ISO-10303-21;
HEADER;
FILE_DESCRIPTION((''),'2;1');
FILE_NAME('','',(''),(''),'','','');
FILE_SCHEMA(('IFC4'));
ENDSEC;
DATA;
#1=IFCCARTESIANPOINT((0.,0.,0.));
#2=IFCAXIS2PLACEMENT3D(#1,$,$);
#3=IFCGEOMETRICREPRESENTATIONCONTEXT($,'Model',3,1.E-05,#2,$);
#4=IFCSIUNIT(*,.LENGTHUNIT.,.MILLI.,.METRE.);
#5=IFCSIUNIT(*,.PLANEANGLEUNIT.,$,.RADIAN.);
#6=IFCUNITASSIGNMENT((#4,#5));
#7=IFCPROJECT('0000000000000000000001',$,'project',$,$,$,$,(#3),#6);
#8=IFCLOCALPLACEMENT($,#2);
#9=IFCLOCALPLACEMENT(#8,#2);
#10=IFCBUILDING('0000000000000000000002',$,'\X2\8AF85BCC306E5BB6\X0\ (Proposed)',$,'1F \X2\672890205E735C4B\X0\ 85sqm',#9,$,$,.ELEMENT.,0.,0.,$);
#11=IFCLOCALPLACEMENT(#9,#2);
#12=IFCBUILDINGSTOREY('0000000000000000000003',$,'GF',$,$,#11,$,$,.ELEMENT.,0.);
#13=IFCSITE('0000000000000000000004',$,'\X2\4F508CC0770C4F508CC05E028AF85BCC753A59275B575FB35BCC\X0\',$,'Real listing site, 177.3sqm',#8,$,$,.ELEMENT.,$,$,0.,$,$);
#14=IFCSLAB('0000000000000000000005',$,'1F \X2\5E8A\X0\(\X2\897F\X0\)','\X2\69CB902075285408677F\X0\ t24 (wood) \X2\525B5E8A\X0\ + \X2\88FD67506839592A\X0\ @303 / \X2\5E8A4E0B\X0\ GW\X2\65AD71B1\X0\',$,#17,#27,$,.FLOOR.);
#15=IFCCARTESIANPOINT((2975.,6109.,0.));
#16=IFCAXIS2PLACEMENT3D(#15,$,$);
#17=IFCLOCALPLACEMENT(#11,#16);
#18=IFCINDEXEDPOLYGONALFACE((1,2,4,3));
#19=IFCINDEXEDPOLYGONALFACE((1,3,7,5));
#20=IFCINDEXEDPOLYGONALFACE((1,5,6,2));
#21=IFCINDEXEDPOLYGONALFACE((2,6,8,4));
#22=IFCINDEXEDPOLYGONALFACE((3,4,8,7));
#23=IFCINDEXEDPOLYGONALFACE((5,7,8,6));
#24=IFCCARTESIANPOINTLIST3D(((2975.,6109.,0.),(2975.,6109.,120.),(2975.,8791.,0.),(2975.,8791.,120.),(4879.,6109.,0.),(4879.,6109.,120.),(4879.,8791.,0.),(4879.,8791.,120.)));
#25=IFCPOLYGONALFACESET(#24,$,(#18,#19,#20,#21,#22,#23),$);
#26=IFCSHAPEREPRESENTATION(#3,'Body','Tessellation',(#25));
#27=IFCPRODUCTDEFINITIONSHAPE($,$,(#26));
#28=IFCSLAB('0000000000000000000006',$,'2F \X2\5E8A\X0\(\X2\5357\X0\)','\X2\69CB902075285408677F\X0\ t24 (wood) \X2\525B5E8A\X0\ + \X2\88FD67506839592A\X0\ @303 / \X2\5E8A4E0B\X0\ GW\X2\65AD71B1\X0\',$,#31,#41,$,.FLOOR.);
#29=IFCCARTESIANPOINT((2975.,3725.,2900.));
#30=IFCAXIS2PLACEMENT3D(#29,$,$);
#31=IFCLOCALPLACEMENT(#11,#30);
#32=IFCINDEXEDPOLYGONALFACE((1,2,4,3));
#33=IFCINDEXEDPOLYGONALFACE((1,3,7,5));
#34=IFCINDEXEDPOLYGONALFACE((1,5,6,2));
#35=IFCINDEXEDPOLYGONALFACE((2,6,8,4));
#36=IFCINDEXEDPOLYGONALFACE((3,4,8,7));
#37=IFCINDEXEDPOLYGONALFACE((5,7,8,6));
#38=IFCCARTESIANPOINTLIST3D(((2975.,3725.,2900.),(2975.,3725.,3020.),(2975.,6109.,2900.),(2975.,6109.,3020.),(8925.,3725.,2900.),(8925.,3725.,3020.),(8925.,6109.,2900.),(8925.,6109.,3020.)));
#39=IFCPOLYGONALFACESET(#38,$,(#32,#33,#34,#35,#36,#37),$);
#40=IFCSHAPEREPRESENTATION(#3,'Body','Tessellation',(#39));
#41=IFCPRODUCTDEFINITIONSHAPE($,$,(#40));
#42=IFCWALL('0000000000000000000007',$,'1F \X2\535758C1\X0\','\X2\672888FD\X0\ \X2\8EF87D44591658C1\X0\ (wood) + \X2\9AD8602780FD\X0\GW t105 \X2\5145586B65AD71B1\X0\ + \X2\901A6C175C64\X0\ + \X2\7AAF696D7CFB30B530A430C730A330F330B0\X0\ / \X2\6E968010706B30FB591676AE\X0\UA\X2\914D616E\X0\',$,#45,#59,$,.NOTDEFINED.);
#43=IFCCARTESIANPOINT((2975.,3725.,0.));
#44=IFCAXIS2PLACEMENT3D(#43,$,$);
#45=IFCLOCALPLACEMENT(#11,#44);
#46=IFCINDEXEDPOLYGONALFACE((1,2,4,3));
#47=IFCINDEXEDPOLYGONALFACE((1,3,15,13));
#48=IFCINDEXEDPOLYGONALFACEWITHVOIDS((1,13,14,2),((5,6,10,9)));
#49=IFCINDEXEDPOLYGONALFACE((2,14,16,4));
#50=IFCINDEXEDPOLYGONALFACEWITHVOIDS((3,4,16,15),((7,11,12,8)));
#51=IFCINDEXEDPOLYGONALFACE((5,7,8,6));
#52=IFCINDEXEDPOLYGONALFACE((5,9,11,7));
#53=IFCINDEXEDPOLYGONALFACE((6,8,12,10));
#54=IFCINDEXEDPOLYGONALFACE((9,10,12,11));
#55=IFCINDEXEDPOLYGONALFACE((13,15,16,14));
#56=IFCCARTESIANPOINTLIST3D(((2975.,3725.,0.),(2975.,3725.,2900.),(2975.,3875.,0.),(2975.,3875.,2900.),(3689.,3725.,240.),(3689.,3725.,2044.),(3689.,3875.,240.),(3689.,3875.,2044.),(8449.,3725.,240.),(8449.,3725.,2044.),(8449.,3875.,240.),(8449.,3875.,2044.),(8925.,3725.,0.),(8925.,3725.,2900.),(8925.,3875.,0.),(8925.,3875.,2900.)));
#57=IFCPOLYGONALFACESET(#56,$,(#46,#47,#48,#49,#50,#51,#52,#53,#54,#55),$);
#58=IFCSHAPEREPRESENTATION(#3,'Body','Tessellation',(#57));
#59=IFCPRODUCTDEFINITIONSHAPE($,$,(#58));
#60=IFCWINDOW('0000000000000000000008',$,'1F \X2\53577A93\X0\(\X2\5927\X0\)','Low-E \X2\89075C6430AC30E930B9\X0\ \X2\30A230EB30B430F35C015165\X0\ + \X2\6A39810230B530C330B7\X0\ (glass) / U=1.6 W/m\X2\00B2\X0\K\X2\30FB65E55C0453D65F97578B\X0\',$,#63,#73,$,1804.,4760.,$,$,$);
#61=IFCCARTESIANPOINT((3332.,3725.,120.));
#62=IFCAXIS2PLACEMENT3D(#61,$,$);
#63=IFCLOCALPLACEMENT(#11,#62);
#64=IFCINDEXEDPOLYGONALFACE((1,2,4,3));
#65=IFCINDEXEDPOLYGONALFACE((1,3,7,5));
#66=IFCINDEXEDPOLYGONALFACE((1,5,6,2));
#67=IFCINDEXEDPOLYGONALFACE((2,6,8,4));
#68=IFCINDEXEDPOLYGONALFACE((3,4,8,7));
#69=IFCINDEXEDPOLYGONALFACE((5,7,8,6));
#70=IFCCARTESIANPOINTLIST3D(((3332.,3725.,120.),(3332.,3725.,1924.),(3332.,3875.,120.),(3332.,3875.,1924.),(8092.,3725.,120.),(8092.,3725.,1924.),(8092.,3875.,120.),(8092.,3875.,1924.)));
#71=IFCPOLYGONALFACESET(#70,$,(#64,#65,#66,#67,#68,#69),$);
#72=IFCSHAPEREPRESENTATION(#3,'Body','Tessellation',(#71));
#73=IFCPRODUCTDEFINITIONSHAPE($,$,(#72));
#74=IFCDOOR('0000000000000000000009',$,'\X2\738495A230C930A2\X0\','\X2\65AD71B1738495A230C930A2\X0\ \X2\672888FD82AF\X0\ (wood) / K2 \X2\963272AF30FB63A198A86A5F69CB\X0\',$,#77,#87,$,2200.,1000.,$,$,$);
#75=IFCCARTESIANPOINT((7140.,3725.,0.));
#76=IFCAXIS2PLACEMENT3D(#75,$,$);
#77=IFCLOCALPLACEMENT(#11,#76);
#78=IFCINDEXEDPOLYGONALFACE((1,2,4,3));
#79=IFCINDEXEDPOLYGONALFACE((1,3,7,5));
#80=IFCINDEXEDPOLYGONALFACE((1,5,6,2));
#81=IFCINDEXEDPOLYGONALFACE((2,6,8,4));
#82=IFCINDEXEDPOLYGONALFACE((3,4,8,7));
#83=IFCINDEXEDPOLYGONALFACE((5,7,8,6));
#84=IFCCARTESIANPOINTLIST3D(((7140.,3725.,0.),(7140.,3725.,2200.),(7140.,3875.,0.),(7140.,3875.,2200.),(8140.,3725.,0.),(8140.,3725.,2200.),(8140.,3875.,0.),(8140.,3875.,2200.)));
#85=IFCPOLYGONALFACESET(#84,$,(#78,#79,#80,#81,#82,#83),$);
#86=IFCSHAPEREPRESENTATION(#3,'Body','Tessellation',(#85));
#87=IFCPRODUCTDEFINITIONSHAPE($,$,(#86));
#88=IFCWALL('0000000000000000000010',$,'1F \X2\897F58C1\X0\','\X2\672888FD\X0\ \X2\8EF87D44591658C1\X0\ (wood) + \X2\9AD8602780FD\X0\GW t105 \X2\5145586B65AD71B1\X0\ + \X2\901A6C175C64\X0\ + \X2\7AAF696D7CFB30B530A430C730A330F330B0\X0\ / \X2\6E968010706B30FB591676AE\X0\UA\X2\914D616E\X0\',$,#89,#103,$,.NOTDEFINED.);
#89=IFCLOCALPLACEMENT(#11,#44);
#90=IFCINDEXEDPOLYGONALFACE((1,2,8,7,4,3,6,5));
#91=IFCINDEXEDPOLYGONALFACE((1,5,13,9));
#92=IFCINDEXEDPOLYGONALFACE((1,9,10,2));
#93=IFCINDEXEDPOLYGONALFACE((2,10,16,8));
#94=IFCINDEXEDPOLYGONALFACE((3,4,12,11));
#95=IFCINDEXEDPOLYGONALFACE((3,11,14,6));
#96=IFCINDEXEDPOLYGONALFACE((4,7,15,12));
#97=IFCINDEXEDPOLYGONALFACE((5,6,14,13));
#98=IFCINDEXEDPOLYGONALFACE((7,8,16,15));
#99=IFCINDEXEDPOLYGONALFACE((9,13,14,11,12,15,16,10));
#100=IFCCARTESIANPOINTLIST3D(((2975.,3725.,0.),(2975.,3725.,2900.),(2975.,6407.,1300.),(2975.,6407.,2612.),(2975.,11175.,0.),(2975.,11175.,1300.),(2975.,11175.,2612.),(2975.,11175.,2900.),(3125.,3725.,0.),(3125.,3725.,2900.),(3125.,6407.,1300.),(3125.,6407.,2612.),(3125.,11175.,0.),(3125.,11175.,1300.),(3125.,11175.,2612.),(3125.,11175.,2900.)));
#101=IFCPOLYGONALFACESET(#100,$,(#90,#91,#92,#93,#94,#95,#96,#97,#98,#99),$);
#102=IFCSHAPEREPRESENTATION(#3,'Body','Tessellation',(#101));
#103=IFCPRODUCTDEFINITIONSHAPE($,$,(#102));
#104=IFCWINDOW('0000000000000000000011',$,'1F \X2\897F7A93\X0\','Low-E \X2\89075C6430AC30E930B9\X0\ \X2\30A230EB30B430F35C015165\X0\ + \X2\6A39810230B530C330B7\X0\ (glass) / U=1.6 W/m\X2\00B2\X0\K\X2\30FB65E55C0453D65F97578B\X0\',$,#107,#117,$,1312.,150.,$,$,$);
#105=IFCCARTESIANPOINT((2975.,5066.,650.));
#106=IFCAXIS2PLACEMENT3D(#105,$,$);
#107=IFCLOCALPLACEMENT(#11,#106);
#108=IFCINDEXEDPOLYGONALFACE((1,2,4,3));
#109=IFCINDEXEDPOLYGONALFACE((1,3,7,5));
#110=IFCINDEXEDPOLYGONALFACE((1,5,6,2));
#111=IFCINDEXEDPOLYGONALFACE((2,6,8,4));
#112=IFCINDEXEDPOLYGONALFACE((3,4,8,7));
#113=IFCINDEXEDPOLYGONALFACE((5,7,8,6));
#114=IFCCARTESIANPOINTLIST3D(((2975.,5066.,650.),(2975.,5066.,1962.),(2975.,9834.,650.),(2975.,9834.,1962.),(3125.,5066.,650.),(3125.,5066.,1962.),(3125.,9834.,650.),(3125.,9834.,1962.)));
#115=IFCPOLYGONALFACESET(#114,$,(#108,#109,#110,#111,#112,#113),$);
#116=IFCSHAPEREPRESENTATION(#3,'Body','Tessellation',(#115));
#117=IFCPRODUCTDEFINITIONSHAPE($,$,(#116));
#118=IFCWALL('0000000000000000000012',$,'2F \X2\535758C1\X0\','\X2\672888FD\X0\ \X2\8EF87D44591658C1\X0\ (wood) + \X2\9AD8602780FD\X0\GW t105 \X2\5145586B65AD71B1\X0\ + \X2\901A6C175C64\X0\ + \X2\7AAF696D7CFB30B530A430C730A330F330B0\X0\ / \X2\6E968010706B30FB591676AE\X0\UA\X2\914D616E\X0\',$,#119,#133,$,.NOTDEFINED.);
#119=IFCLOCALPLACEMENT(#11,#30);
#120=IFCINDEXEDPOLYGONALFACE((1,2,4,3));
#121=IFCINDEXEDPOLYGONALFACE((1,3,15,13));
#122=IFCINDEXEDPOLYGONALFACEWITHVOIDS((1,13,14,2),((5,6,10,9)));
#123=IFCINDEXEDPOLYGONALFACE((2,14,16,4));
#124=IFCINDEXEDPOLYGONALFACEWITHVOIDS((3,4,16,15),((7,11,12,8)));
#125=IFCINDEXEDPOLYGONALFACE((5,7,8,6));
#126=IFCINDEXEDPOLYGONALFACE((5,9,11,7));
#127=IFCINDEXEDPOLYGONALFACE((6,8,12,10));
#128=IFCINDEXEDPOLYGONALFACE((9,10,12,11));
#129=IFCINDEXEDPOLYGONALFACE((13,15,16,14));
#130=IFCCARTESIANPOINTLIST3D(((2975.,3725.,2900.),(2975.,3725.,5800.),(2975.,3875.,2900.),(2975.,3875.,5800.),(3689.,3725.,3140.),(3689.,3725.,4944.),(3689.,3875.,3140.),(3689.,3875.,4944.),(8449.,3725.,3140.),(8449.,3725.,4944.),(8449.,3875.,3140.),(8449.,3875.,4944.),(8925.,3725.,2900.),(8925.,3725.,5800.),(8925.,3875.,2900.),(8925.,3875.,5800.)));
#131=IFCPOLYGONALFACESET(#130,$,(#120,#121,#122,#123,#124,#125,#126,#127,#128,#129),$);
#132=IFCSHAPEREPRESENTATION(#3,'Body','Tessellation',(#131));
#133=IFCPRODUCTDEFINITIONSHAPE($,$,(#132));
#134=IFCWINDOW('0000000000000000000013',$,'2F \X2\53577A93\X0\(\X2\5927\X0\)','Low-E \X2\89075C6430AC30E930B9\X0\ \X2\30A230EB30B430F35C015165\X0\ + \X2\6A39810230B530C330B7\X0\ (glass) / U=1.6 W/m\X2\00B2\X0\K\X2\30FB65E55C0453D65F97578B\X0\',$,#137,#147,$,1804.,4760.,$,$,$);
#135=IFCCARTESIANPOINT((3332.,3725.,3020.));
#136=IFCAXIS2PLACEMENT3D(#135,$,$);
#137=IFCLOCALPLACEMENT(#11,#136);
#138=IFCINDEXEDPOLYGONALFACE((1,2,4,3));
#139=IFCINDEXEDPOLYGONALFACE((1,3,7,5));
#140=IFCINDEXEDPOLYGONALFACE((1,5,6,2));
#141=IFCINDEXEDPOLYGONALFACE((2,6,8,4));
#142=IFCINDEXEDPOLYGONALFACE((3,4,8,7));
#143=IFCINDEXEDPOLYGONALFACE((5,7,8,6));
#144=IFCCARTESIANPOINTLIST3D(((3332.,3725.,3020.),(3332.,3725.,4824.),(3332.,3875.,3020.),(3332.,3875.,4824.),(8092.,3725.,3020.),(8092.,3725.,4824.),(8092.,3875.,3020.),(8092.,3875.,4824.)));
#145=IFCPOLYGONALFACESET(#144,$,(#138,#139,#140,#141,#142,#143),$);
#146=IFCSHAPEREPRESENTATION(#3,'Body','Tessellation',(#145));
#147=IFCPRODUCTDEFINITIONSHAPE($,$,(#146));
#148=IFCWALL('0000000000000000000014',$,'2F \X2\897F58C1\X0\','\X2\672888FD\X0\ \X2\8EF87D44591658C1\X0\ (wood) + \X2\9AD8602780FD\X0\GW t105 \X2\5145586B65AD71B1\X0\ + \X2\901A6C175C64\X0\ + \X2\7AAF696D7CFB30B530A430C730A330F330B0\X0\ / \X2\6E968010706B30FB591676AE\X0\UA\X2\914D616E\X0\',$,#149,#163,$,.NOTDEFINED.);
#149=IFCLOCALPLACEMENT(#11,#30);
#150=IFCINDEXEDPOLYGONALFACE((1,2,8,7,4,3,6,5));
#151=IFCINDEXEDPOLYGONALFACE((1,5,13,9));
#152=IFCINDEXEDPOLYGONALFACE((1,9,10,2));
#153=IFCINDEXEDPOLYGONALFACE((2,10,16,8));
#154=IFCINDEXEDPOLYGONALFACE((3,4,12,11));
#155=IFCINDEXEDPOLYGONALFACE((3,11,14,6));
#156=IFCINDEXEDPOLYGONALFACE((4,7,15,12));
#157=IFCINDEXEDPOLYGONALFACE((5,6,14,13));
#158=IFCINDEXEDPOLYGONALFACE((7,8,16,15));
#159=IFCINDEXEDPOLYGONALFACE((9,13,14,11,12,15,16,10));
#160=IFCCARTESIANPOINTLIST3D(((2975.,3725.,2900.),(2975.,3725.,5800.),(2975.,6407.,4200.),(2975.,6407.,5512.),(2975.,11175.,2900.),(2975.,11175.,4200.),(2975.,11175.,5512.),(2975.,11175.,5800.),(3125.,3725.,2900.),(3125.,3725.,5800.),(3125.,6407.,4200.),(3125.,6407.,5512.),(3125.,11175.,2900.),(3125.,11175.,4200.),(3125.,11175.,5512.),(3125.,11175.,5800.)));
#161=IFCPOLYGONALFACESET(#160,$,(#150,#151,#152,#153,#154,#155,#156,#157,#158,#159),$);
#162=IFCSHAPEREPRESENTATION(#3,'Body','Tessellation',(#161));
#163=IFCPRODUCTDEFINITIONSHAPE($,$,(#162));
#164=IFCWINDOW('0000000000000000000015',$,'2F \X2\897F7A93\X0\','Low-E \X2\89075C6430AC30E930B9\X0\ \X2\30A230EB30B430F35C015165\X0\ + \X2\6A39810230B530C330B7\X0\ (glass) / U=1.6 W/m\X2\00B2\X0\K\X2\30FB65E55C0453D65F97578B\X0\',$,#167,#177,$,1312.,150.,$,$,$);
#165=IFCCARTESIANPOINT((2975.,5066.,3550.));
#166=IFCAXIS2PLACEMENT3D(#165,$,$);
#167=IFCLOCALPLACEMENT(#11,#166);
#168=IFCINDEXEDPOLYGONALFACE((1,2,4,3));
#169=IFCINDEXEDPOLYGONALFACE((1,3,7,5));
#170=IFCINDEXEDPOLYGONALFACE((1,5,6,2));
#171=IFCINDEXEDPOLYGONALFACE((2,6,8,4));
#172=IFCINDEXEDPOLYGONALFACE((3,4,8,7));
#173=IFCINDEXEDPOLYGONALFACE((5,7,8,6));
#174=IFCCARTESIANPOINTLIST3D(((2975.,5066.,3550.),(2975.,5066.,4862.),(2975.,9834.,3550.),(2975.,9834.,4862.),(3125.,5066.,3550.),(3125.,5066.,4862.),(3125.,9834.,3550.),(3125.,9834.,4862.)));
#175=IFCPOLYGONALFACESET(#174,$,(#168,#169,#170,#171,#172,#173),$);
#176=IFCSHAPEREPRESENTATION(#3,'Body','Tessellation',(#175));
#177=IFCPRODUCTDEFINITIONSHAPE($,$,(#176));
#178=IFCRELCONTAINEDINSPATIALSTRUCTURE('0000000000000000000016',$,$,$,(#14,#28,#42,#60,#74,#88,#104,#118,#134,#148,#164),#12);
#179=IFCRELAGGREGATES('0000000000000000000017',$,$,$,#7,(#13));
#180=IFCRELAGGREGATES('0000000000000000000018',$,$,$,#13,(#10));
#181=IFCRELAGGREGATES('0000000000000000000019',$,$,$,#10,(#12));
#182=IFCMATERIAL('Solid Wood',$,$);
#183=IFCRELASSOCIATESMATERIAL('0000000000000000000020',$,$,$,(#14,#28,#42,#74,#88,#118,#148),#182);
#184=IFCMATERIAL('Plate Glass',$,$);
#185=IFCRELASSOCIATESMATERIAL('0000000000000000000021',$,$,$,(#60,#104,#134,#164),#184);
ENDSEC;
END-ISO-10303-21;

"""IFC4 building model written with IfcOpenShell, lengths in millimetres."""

from ifc_helpers import new_model, si_unit, frame, frame_2d, origin, place, context, project, spatial, rectangle, extrude, material, element, fill, save


model = new_model("IFC4")

# Units and contexts
model_context = context("Model", 3, precision=1e-05, world=origin())
ifc_project = project(units=[si_unit("LENGTHUNIT", "METRE", prefix="MILLI"), si_unit("PLANEANGLEUNIT", "RADIAN")], contexts=[model_context])

# Site, building, storey
site_placement = place(None, origin())
site = spatial("IfcSite", under=ifc_project, at=site_placement, Name="佐賀県佐賀市諸富町大字徳富", ObjectType="Real listing site, 177.3sqm", CompositionType="ELEMENT", RefElevation=0.0)
building_placement = place(site_placement, origin())
building = spatial("IfcBuilding", under=site, at=building_placement, Name="諸富の家 (Proposed)", ObjectType="1F 木造平屋 85sqm", CompositionType="ELEMENT", ElevationOfRefHeight=0.0, ElevationOfTerrain=0.0)
storey_placement = place(building_placement, origin())
storey = spatial("IfcBuildingStorey", under=building, at=storey_placement, Name="GF", CompositionType="ELEMENT", Elevation=0.0)

# Slabs
ifc_material_1 = material(Name="Solid Wood")
slab_1_placement = place(storey_placement, frame((2975.0, 6109.0, 0.0)))
element("IfcSlab", 1, at=slab_1_placement, inside=storey, material=ifc_material_1, Name="1F 床(西)", Description="構造用合板 t24 (wood) 剛床 + 製材根太 @303 / 床下 GW断熱", PredefinedType="FLOOR", context=model_context, shape_type="SweptSolid", body=[
    extrude(rectangle(XDim=1904.0, YDim=2682.0, at=frame_2d((952.0, 1341.0))), frame((2975.0, 6109.0, 0.0)), (0.0, 0.0, 1.0), 120.0),
])
slab_2_placement = place(storey_placement, frame((2975.0, 3725.0, 2900.0)))
element("IfcSlab", 2, at=slab_2_placement, inside=storey, material=ifc_material_1, Name="2F 床(南)", Description="構造用合板 t24 (wood) 剛床 + 製材根太 @303 / 床下 GW断熱", PredefinedType="FLOOR", context=model_context, shape_type="SweptSolid", body=[
    extrude(rectangle(XDim=5950.0, YDim=2384.0, at=frame_2d((2975.0, 1192.0))), frame((2975.0, 3725.0, 2900.0)), (0.0, 0.0, 1.0), 120.0),
])

# Wall, openings, window, door
wall_1_placement = place(storey_placement, frame((2975.0, 3725.0, 0.0)))
wall_1 = element("IfcWall", 3, at=wall_1_placement, inside=storey, material=ifc_material_1, Name="1F 南壁", Description="木製 軸組外壁 (wood) + 高性能GW t105 充填断熱 + 通気層 + 窯業系サイディング / 準耐火・外皮UA配慮", PredefinedType="NOTDEFINED", context=model_context, shape_type="SweptSolid", body=[
    extrude(rectangle(XDim=5950.0, YDim=150.0, at=frame_2d((2975.0, 75.0))), frame((2975.0, 3725.0, 0.0)), (0.0, 0.0, 1.0), 2900.0),
])
opening_1_placement = place(storey_placement, frame((3332.0, 3725.0, 120.0)))
opening_1 = element("IfcOpeningElement", 4, at=opening_1_placement, cuts=wall_1, PredefinedType="NOTDEFINED", context=model_context, shape_type="SweptSolid", body=[
    extrude(rectangle(XDim=4760.0, YDim=150.0, at=frame_2d((2380.0, 75.0))), frame((3332.0, 3725.0, 120.0)), (0.0, 0.0, 1.0), 1804.0),
])
opening_2_placement = place(storey_placement, frame((7140.0, 3725.0, 0.0)))
opening_2 = element("IfcOpeningElement", 5, at=opening_2_placement, cuts=wall_1, PredefinedType="NOTDEFINED", context=model_context, shape_type="SweptSolid", body=[
    extrude(rectangle(XDim=1000.0, YDim=150.0, at=frame_2d((500.0, 75.0))), frame((7140.0, 3725.0, 0.0)), (0.0, 0.0, 1.0), 2200.0),
])
ifc_material_2 = material(Name="Plate Glass")
window_1_placement = place(storey_placement, frame((3332.0, 3725.0, 120.0)))
window_1 = element("IfcWindow", 6, at=window_1_placement, inside=storey, material=ifc_material_2, Name="1F 南窓(大)", Description="Low-E 複層ガラス アルゴン封入 + 樹脂サッシ (glass) / U=1.6 W/m²K・日射取得型", OverallHeight=1804.0, OverallWidth=4760.0, context=model_context, shape_type="SweptSolid", body=[
    extrude(rectangle(XDim=4760.0, YDim=150.0, at=frame_2d((2380.0, 75.0))), frame((3332.0, 3725.0, 120.0)), (0.0, 0.0, 1.0), 1804.0),
])
fill(opening_1, window_1)
door_placement = place(storey_placement, frame((7140.0, 3725.0, 0.0)))
door = element("IfcDoor", 7, at=door_placement, inside=storey, material=ifc_material_1, Name="玄関ドア", Description="断熱玄関ドア 木製芯 (wood) / K2 防犯・採風機構", OverallHeight=2200.0, OverallWidth=1000.0, context=model_context, shape_type="SweptSolid", body=[
    extrude(rectangle(XDim=1000.0, YDim=150.0, at=frame_2d((500.0, 75.0))), frame((7140.0, 3725.0, 0.0)), (0.0, 0.0, 1.0), 2200.0),
])
fill(opening_2, door)

# Walls, openings, windows
wall_2_placement = place(storey_placement, frame((2975.0, 3725.0, 0.0)))
wall_2 = element("IfcWall", 8, at=wall_2_placement, inside=storey, material=ifc_material_1, Name="1F 西壁", Description="木製 軸組外壁 (wood) + 高性能GW t105 充填断熱 + 通気層 + 窯業系サイディング / 準耐火・外皮UA配慮", PredefinedType="NOTDEFINED", context=model_context, shape_type="SweptSolid", body=[
    extrude(rectangle(XDim=150.0, YDim=7450.0, at=frame_2d((75.0, 3725.0))), frame((2975.0, 3725.0, 0.0)), (0.0, 0.0, 1.0), 2900.0),
])
opening_3_placement = place(storey_placement, frame((2975.0, 5066.0, 650.0)))
opening_3 = element("IfcOpeningElement", 9, at=opening_3_placement, cuts=wall_2, PredefinedType="NOTDEFINED", context=model_context, shape_type="SweptSolid", body=[
    extrude(rectangle(XDim=150.0, YDim=4768.0, at=frame_2d((75.0, 2384.0))), frame((2975.0, 5066.0, 650.0)), (0.0, 0.0, 1.0), 1312.0),
])
window_2_placement = place(storey_placement, frame((2975.0, 5066.0, 650.0)))
window_2 = element("IfcWindow", 10, at=window_2_placement, inside=storey, material=ifc_material_2, Name="1F 西窓", Description="Low-E 複層ガラス アルゴン封入 + 樹脂サッシ (glass) / U=1.6 W/m²K・日射取得型", OverallHeight=1312.0, OverallWidth=150.0, context=model_context, shape_type="SweptSolid", body=[
    extrude(rectangle(XDim=150.0, YDim=4768.0, at=frame_2d((75.0, 2384.0))), frame((2975.0, 5066.0, 650.0)), (0.0, 0.0, 1.0), 1312.0),
])
fill(opening_3, window_2)
wall_3_placement = place(storey_placement, frame((2975.0, 3725.0, 2900.0)))
wall_3 = element("IfcWall", 11, at=wall_3_placement, inside=storey, material=ifc_material_1, Name="2F 南壁", Description="木製 軸組外壁 (wood) + 高性能GW t105 充填断熱 + 通気層 + 窯業系サイディング / 準耐火・外皮UA配慮", PredefinedType="NOTDEFINED", context=model_context, shape_type="SweptSolid", body=[
    extrude(rectangle(XDim=5950.0, YDim=150.0, at=frame_2d((2975.0, 75.0))), frame((2975.0, 3725.0, 2900.0)), (0.0, 0.0, 1.0), 2900.0),
])
opening_4_placement = place(storey_placement, frame((3332.0, 3725.0, 3020.0)))
opening_4 = element("IfcOpeningElement", 12, at=opening_4_placement, cuts=wall_3, PredefinedType="NOTDEFINED", context=model_context, shape_type="SweptSolid", body=[
    extrude(rectangle(XDim=4760.0, YDim=150.0, at=frame_2d((2380.0, 75.0))), frame((3332.0, 3725.0, 3020.0)), (0.0, 0.0, 1.0), 1804.0),
])
window_3_placement = place(storey_placement, frame((3332.0, 3725.0, 3020.0)))
window_3 = element("IfcWindow", 13, at=window_3_placement, inside=storey, material=ifc_material_2, Name="2F 南窓(大)", Description="Low-E 複層ガラス アルゴン封入 + 樹脂サッシ (glass) / U=1.6 W/m²K・日射取得型", OverallHeight=1804.0, OverallWidth=4760.0, context=model_context, shape_type="SweptSolid", body=[
    extrude(rectangle(XDim=4760.0, YDim=150.0, at=frame_2d((2380.0, 75.0))), frame((3332.0, 3725.0, 3020.0)), (0.0, 0.0, 1.0), 1804.0),
])
fill(opening_4, window_3)
wall_4_placement = place(storey_placement, frame((2975.0, 3725.0, 2900.0)))
wall_4 = element("IfcWall", 14, at=wall_4_placement, inside=storey, material=ifc_material_1, Name="2F 西壁", Description="木製 軸組外壁 (wood) + 高性能GW t105 充填断熱 + 通気層 + 窯業系サイディング / 準耐火・外皮UA配慮", PredefinedType="NOTDEFINED", context=model_context, shape_type="SweptSolid", body=[
    extrude(rectangle(XDim=150.0, YDim=7450.0, at=frame_2d((75.0, 3725.0))), frame((2975.0, 3725.0, 2900.0)), (0.0, 0.0, 1.0), 2900.0),
])
opening_5_placement = place(storey_placement, frame((2975.0, 5066.0, 3550.0)))
opening_5 = element("IfcOpeningElement", 15, at=opening_5_placement, cuts=wall_4, PredefinedType="NOTDEFINED", context=model_context, shape_type="SweptSolid", body=[
    extrude(rectangle(XDim=150.0, YDim=4768.0, at=frame_2d((75.0, 2384.0))), frame((2975.0, 5066.0, 3550.0)), (0.0, 0.0, 1.0), 1312.0),
])
window_4_placement = place(storey_placement, frame((2975.0, 5066.0, 3550.0)))
window_4 = element("IfcWindow", 16, at=window_4_placement, inside=storey, material=ifc_material_2, Name="2F 西窓", Description="Low-E 複層ガラス アルゴン封入 + 樹脂サッシ (glass) / U=1.6 W/m²K・日射取得型", OverallHeight=1312.0, OverallWidth=150.0, context=model_context, shape_type="SweptSolid", body=[
    extrude(rectangle(XDim=150.0, YDim=4768.0, at=frame_2d((75.0, 2384.0))), frame((2975.0, 5066.0, 3550.0)), (0.0, 0.0, 1.0), 1312.0),
])
fill(opening_5, window_4)

save(model, "model.ifc")
